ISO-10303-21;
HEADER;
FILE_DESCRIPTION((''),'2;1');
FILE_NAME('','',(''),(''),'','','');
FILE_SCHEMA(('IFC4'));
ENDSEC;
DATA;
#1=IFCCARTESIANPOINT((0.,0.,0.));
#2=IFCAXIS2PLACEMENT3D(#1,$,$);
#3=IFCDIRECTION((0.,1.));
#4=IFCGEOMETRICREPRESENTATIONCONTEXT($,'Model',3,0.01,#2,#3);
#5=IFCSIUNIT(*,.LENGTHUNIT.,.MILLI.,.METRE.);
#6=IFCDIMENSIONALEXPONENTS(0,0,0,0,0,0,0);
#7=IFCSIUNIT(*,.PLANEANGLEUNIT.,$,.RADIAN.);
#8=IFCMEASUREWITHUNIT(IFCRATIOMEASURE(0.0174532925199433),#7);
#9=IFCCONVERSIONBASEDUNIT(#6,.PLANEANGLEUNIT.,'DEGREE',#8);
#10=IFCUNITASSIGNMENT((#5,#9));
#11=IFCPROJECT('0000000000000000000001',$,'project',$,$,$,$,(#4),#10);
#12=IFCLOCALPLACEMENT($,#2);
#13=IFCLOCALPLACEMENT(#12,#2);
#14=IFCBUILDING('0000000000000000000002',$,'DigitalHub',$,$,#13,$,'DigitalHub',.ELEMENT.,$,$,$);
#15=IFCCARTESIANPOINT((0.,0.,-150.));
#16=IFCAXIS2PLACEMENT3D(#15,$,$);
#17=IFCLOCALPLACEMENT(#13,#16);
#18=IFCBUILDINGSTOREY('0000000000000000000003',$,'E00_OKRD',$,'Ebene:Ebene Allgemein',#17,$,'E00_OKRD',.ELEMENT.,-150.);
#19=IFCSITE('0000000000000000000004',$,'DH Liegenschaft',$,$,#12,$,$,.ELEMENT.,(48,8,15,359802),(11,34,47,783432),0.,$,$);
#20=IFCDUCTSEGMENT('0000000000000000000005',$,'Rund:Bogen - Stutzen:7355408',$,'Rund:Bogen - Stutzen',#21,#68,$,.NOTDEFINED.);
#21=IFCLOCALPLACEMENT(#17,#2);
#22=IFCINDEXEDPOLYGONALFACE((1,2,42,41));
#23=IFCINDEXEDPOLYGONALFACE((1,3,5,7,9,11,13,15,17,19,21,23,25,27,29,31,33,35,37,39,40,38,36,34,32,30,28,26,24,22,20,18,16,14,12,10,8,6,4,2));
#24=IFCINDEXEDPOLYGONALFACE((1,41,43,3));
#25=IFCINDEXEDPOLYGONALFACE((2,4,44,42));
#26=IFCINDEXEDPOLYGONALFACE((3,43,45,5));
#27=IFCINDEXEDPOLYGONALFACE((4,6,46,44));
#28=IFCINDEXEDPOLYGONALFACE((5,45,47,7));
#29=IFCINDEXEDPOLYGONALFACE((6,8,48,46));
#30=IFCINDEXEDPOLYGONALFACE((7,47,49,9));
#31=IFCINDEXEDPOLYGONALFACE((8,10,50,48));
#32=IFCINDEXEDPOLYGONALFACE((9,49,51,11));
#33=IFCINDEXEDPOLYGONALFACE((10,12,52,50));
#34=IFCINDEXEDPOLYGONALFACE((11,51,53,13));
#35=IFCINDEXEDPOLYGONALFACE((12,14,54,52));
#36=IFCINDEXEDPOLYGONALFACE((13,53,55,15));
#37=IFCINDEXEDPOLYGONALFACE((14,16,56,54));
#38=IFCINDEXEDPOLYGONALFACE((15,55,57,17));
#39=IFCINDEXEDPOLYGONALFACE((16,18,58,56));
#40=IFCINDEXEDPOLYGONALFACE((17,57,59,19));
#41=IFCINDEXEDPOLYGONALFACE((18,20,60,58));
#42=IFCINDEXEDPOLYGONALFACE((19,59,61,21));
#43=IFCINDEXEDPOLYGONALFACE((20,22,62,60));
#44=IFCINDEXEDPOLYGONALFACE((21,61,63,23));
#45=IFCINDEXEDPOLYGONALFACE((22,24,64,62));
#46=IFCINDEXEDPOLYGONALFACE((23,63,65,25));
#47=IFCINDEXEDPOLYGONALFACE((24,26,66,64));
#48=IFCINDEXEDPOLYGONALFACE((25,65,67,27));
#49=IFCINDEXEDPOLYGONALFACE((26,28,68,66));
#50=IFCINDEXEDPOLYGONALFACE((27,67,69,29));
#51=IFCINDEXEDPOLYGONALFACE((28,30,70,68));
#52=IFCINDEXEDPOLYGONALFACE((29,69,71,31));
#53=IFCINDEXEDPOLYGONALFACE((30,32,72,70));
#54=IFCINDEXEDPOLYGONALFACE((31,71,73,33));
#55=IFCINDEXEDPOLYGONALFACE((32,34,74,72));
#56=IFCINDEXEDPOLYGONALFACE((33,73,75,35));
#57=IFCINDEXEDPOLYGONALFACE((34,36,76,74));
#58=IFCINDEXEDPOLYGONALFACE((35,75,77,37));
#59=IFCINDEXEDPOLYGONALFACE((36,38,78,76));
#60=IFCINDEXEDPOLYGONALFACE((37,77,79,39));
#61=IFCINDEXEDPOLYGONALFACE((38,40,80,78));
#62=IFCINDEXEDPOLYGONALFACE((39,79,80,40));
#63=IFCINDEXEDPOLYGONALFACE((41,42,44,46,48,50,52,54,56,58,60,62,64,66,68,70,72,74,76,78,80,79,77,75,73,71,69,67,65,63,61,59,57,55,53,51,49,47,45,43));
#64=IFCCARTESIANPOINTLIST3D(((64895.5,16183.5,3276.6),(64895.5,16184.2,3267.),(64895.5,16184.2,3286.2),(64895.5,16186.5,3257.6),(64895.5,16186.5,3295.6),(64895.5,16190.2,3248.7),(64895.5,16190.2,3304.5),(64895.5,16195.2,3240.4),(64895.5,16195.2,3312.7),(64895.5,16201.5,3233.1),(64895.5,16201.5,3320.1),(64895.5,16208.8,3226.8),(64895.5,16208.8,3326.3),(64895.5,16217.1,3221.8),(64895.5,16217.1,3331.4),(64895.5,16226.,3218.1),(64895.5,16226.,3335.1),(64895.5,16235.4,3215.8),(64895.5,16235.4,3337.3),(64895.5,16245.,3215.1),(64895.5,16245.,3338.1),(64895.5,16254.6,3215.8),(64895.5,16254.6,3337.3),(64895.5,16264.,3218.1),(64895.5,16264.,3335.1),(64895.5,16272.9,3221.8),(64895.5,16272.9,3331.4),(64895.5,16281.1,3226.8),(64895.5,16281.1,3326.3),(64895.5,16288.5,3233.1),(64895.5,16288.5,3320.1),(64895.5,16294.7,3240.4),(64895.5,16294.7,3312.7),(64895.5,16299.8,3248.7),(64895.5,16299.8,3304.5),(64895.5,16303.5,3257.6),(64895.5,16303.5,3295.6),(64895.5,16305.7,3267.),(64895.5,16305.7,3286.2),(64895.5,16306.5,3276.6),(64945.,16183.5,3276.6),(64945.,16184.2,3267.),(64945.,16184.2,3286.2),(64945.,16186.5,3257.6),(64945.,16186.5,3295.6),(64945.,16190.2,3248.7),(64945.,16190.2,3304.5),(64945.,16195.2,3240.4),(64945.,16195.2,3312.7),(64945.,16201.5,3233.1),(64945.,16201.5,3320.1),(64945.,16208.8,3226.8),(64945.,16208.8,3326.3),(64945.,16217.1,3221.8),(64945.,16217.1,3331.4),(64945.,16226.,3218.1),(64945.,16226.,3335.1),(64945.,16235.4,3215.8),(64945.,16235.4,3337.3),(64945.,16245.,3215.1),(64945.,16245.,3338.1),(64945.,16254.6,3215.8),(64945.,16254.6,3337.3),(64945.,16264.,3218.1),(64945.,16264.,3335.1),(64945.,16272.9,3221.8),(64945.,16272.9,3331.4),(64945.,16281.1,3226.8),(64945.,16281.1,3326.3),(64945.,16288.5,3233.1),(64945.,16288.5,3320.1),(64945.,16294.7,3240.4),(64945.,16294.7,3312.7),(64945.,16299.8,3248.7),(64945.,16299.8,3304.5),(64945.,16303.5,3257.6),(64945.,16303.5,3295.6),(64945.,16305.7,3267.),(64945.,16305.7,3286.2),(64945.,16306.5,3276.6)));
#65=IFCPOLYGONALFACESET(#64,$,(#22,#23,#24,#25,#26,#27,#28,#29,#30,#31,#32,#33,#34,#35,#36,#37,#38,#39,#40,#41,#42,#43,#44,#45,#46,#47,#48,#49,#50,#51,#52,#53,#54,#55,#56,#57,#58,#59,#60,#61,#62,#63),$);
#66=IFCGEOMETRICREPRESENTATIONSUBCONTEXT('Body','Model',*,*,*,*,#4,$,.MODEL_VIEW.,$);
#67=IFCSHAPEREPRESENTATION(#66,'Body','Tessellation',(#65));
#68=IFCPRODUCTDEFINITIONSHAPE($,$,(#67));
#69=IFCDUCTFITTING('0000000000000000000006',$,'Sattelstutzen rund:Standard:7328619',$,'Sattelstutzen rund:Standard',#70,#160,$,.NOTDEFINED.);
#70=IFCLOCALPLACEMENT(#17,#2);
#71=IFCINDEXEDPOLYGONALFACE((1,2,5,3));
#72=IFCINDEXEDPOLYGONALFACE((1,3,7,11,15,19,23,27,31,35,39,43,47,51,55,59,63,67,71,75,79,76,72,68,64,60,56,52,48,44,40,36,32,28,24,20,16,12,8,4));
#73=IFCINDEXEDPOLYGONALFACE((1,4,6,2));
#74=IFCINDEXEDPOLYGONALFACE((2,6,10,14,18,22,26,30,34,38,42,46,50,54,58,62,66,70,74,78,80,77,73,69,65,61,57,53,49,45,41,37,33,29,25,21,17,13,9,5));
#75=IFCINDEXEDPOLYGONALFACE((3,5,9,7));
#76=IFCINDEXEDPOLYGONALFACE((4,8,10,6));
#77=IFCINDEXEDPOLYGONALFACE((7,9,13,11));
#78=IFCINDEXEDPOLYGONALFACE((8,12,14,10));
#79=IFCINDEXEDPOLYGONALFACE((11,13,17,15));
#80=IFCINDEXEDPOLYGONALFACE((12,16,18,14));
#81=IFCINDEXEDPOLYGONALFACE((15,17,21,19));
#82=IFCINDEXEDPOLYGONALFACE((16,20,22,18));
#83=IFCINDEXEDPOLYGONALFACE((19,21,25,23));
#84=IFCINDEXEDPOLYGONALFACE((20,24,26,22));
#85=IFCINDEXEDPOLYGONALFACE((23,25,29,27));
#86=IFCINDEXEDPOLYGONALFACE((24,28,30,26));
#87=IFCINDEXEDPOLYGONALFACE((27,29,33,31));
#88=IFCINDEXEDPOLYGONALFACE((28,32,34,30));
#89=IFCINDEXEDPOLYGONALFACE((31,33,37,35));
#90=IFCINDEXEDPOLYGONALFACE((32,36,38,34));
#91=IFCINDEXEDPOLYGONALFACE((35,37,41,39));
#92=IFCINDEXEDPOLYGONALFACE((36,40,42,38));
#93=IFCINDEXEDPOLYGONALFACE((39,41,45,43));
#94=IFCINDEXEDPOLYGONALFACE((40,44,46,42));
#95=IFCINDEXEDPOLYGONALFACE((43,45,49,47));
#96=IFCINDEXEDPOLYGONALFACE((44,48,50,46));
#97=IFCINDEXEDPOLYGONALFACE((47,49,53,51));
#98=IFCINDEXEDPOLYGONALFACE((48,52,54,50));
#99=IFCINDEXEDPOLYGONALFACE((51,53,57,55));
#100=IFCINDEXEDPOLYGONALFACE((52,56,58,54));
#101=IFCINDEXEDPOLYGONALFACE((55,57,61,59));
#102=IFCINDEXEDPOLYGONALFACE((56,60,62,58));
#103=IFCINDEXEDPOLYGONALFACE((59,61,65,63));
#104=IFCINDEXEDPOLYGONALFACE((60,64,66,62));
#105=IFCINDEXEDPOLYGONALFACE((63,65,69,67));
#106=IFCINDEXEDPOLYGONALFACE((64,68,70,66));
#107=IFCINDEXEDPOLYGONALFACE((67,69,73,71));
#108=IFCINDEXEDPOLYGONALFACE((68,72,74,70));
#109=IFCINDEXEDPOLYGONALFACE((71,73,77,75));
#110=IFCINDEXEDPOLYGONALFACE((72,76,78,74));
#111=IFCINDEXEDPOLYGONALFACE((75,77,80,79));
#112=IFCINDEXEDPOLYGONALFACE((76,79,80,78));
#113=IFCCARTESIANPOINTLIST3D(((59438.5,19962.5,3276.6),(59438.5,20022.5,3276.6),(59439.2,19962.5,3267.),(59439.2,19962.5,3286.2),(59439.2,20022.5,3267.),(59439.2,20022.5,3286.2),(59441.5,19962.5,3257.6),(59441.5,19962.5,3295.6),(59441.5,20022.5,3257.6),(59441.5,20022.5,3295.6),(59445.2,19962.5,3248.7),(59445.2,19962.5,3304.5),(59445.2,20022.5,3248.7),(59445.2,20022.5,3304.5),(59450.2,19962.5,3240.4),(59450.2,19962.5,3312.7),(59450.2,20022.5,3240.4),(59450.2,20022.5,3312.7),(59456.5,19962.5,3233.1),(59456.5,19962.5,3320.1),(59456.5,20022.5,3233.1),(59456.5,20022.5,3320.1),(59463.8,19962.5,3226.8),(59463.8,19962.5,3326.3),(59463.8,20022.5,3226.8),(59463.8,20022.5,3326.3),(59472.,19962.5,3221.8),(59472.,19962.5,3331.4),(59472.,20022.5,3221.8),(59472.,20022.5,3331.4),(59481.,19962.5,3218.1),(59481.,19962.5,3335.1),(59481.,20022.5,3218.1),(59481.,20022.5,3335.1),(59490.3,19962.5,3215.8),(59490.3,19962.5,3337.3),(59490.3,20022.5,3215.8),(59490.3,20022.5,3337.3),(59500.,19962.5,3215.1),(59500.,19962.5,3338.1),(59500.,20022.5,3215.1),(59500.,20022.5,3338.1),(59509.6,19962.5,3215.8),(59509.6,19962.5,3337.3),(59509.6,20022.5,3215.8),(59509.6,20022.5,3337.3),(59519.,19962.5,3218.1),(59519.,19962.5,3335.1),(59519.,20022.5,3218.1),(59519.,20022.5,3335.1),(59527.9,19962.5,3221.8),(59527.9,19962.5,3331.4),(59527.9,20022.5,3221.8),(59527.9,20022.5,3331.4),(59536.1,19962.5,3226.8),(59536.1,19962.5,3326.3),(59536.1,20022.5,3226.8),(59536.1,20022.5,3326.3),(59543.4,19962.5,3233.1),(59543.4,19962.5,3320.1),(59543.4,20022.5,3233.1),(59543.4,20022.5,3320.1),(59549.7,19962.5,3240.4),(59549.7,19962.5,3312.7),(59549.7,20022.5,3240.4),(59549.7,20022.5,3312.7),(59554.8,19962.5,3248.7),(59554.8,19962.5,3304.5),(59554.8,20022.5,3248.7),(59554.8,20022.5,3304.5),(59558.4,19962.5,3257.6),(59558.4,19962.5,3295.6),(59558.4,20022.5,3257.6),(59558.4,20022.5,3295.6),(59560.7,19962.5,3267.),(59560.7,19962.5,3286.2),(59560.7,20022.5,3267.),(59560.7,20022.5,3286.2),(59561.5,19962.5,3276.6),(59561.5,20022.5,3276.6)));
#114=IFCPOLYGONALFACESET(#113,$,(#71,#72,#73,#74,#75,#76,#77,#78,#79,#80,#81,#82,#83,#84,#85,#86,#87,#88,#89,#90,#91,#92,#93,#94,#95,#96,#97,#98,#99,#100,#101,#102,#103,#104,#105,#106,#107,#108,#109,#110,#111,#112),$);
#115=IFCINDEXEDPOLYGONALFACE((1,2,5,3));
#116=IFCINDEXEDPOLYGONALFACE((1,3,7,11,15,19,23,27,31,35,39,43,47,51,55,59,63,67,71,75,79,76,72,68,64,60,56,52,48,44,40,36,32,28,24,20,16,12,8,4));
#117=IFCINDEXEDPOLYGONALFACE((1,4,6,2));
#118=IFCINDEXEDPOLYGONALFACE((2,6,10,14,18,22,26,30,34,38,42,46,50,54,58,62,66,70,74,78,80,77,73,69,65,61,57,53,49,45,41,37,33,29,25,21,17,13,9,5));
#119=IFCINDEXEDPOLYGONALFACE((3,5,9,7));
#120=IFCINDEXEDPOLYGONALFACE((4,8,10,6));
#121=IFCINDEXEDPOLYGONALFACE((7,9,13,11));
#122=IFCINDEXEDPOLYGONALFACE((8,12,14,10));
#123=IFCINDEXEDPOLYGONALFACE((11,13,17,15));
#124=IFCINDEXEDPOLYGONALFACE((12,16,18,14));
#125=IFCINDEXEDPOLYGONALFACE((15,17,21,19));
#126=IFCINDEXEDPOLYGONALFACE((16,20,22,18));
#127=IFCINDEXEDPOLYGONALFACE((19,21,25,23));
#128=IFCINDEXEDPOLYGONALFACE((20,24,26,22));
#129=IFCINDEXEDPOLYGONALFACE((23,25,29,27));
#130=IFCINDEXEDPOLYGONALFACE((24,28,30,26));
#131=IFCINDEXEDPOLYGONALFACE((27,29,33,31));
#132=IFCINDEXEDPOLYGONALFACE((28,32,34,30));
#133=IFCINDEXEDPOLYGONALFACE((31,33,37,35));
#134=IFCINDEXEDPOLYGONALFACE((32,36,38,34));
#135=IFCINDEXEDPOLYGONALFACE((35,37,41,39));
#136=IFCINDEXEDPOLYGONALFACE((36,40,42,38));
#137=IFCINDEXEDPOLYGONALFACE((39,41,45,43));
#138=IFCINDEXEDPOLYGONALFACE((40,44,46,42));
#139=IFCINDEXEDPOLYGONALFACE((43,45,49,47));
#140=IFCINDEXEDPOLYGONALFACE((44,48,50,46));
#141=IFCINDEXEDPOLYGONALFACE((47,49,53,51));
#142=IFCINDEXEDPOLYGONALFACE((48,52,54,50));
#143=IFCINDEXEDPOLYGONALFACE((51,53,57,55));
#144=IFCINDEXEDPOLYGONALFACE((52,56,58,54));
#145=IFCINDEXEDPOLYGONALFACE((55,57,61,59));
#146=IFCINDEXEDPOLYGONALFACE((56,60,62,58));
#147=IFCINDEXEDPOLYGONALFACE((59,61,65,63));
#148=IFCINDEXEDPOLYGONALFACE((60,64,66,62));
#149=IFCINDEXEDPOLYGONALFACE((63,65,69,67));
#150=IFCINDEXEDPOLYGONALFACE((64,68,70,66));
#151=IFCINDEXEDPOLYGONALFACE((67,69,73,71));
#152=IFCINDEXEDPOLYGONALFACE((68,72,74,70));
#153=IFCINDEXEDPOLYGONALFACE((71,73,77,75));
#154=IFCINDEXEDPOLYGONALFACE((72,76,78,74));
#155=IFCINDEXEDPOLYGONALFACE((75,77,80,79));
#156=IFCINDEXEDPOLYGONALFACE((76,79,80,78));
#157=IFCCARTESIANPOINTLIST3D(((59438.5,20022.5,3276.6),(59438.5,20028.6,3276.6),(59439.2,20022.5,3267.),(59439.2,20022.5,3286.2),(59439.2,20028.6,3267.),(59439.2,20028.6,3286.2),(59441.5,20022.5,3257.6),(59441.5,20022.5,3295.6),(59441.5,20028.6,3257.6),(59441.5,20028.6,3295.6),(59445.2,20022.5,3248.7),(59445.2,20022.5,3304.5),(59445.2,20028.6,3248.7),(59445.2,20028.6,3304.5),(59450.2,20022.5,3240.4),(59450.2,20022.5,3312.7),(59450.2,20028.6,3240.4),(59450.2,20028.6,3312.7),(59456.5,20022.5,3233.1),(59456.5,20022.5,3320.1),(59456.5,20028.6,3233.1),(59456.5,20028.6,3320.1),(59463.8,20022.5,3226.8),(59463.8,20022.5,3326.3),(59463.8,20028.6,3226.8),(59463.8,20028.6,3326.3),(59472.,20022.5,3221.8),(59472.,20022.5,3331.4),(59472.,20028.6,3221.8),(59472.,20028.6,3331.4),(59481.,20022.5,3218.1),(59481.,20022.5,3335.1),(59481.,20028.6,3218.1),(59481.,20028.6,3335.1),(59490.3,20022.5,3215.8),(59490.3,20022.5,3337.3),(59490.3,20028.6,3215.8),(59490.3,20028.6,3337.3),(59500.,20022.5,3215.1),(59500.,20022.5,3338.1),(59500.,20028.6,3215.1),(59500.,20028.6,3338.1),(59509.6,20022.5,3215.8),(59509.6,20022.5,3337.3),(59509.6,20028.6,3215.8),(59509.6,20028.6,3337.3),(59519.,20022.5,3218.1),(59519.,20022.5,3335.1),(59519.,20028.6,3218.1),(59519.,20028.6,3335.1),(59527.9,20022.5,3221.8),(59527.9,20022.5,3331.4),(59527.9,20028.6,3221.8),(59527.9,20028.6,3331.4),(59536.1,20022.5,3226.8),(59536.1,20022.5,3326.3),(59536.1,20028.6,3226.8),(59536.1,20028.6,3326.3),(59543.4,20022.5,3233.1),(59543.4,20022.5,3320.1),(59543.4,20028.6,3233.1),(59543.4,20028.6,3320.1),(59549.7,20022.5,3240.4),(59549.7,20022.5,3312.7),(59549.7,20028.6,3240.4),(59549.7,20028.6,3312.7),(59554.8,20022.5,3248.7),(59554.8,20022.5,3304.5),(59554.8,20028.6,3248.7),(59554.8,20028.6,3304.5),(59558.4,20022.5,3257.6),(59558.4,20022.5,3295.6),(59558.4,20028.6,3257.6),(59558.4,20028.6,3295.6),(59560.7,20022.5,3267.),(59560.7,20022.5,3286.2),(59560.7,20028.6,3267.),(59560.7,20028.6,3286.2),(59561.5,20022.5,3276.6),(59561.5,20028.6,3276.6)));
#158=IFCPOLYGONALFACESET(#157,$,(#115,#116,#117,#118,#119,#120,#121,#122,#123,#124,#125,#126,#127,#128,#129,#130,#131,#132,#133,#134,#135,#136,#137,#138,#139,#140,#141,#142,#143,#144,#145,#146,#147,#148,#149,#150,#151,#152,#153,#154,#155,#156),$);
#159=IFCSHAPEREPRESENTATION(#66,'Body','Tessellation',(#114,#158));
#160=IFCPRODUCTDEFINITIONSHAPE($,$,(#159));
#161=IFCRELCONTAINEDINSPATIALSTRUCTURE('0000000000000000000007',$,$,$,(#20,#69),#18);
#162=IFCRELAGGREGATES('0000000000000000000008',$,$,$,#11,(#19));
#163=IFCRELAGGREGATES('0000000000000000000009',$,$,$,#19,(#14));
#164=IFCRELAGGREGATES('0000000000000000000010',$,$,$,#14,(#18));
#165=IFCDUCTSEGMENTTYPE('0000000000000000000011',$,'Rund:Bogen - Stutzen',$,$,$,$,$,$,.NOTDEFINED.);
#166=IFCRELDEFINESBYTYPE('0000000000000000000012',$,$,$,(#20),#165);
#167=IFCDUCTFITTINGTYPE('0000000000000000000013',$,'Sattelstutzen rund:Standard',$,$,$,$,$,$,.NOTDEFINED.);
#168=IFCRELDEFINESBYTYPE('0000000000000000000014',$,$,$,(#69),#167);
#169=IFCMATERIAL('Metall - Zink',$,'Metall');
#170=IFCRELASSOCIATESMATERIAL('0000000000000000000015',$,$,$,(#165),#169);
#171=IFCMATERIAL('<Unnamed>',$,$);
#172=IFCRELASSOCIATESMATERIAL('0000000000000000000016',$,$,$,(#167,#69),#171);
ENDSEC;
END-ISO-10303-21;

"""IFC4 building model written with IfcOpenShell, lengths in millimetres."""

from ifc_helpers import new_model, entity, si_unit, converted_unit, direction, frame, origin, place, context, subcontext, project, spatial, indexed_curve, outline, extrude, source, transform, mapped, material, type_object, type_shapes, element, save


model = new_model("IFC4")

# Units and contexts
model_context = context("Model", 3, precision=0.01, world=origin(), true_north=direction((0.0, 1.0)))
body_context = subcontext(model_context, "Body", "Model", "MODEL_VIEW")
ifc_project = project(units=[si_unit("LENGTHUNIT", "METRE", prefix="MILLI"), converted_unit("PLANEANGLEUNIT", "DEGREE", entity("IfcRatioMeasure", 0.0174532925199433), si_unit("PLANEANGLEUNIT", "RADIAN"), dimensions=[0, 0, 0, 0, 0, 0, 0])], contexts=[model_context])

# Site, building, storey
site_placement = place(None, origin())
site = spatial("IfcSite", under=ifc_project, at=site_placement, Name="DH Liegenschaft", CompositionType="ELEMENT", RefLatitude=(48, 8, 15, 359802), RefLongitude=(11, 34, 47, 783432), RefElevation=0.0)
building_placement = place(site_placement, origin())
building = spatial("IfcBuilding", under=site, at=building_placement, Name="DigitalHub", LongName="DigitalHub", CompositionType="ELEMENT")
storey_placement = place(building_placement, frame((0.0, 0.0, -150.0)))
storey = spatial("IfcBuildingStorey", under=building, at=storey_placement, Name="E00_OKRD", ObjectType="Ebene:Ebene Allgemein", LongName="E00_OKRD", CompositionType="ELEMENT", Elevation=-150.0)

# Shared definitions
ifc_material_1 = material(Name="Metall - Zink", Category="Metall")

# Shared definitions
ifc_material_2 = material(Name="<Unnamed>")

# Duct segment
duct_segment_type_1 = type_object("IfcDuctSegmentType", Name="Rund:Bogen - Stutzen", PredefinedType="NOTDEFINED", material=ifc_material_1)
duct_segment_1_placement = place(storey_placement, frame((64895.5, 16181.9, 3213.5)))
element("IfcDuctSegment", 1, at=duct_segment_1_placement, inside=storey, type_object=duct_segment_type_1, Name="Rund:Bogen - Stutzen:7355408", ObjectType="Rund:Bogen - Stutzen", PredefinedType="NOTDEFINED", context=body_context, shape_type="SweptSolid", body=[
    extrude(outline(indexed_curve([(61.5, 0.0), (60.7, 9.6), (58.5, 19.0), (54.8, 27.9), (49.8, 36.1), (43.5, 43.5), (36.1, 49.8), (27.9, 54.8), (19.0, 58.5), (9.6, 60.7), (0.0, 61.5), (-9.6, 60.7), (-19.0, 58.5), (-27.9, 54.8), (-36.1, 49.8), (-43.5, 43.5), (-49.8, 36.1), (-54.8, 27.9), (-58.5, 19.0), (-60.7, 9.6), (-61.5, 0.0), (-60.7, -9.6), (-58.5, -19.0), (-54.8, -27.9), (-49.8, -36.1), (-43.5, -43.5), (-36.1, -49.8), (-27.9, -54.8), (-19.0, -58.5), (-9.6, -60.7), (0.0, -61.5), (9.6, -60.7), (19.0, -58.5), (27.9, -54.8), (36.1, -49.8), (43.5, -43.5), (49.8, -36.1), (54.8, -27.9), (58.5, -19.0), (60.7, -9.6), (61.5, 0.0)], self_intersect=False)), frame((0.0, 63.1, 63.1), z_axis=(1.0, 0.0, 0.0), x_axis=(0.0, 1.0, 0.0)), (0.0, 0.0, 1.0), 49.5),
])

# Duct fitting
duct_fitting_type_1 = type_object("IfcDuctFittingType", Name="Sattelstutzen rund:Standard", PredefinedType="NOTDEFINED", material=ifc_material_2)
shared_shape_1 = source(origin(), body_context, "Body", "SweptSolid", [
    extrude(outline(indexed_curve([(0.0, -61.5), (9.6, -60.7), (19.0, -58.5), (27.9, -54.8), (36.1, -49.8), (43.5, -43.5), (49.8, -36.1), (54.8, -27.9), (58.5, -19.0), (60.7, -9.6), (61.5, 0.0), (60.7, 9.6), (58.5, 19.0), (54.8, 27.9), (49.8, 36.1), (43.5, 43.5), (36.1, 49.8), (27.9, 54.8), (19.0, 58.5), (9.6, 60.7), (0.0, 61.5), (-9.6, 60.7), (-19.0, 58.5), (-27.9, 54.8), (-36.1, 49.8), (-43.5, 43.5), (-49.8, 36.1), (-54.8, 27.9), (-58.5, 19.0), (-60.7, 9.6), (-61.5, 0.0), (-60.7, -9.6), (-58.5, -19.0), (-54.8, -27.9), (-49.8, -36.1), (-43.5, -43.5), (-36.1, -49.8), (-27.9, -54.8), (-19.0, -58.5), (-9.6, -60.7), (0.0, -61.5)], self_intersect=False)), frame((0.0, 0.0, 0.0), z_axis=(1.0, 0.0, 0.0), x_axis=(0.0, -1.0, 0.0)), (0.0, 0.0, 1.0), 60.0),
    extrude(outline(indexed_curve([(0.0, -61.5), (9.6, -60.7), (19.0, -58.5), (27.9, -54.8), (36.1, -49.8), (43.5, -43.5), (49.8, -36.1), (54.8, -27.9), (58.5, -19.0), (60.7, -9.6), (61.5, 0.0), (60.7, 9.6), (58.5, 19.0), (54.8, 27.9), (49.8, 36.1), (43.5, 43.5), (36.1, 49.8), (27.9, 54.8), (19.0, 58.5), (9.6, 60.7), (0.0, 61.5), (-9.6, 60.7), (-19.0, 58.5), (-27.9, 54.8), (-36.1, 49.8), (-43.5, 43.5), (-49.8, 36.1), (-54.8, 27.9), (-58.5, 19.0), (-60.7, 9.6), (-61.5, 0.0), (-60.7, -9.6), (-58.5, -19.0), (-54.8, -27.9), (-49.8, -36.1), (-43.5, -43.5), (-36.1, -49.8), (-27.9, -54.8), (-19.0, -58.5), (-9.6, -60.7), (0.0, -61.5)], self_intersect=False)), frame((-6.1, 0.0, 0.0), z_axis=(1.0, 0.0, 0.0), x_axis=(0.0, -1.0, 0.0)), (0.0, 0.0, 1.0), 6.1),
])
type_shapes(duct_fitting_type_1, [shared_shape_1])
duct_fitting_1_placement = place(storey_placement, frame((59500.0, 20022.5, 3276.6), z_axis=(0.0, 0.0, -1.0), x_axis=(0.0, -1.0, 0.0)))
element("IfcDuctFitting", 2, at=duct_fitting_1_placement, inside=storey, type_object=duct_fitting_type_1, material=ifc_material_2, Name="Sattelstutzen rund:Standard:7328619", ObjectType="Sattelstutzen rund:Standard", PredefinedType="NOTDEFINED", context=body_context, shape_type="MappedRepresentation", body=[
    mapped(shared_shape_1, transform((0.0, 0.0, 0.0), scale=1.0)),
])

save(model, "model.ifc")
